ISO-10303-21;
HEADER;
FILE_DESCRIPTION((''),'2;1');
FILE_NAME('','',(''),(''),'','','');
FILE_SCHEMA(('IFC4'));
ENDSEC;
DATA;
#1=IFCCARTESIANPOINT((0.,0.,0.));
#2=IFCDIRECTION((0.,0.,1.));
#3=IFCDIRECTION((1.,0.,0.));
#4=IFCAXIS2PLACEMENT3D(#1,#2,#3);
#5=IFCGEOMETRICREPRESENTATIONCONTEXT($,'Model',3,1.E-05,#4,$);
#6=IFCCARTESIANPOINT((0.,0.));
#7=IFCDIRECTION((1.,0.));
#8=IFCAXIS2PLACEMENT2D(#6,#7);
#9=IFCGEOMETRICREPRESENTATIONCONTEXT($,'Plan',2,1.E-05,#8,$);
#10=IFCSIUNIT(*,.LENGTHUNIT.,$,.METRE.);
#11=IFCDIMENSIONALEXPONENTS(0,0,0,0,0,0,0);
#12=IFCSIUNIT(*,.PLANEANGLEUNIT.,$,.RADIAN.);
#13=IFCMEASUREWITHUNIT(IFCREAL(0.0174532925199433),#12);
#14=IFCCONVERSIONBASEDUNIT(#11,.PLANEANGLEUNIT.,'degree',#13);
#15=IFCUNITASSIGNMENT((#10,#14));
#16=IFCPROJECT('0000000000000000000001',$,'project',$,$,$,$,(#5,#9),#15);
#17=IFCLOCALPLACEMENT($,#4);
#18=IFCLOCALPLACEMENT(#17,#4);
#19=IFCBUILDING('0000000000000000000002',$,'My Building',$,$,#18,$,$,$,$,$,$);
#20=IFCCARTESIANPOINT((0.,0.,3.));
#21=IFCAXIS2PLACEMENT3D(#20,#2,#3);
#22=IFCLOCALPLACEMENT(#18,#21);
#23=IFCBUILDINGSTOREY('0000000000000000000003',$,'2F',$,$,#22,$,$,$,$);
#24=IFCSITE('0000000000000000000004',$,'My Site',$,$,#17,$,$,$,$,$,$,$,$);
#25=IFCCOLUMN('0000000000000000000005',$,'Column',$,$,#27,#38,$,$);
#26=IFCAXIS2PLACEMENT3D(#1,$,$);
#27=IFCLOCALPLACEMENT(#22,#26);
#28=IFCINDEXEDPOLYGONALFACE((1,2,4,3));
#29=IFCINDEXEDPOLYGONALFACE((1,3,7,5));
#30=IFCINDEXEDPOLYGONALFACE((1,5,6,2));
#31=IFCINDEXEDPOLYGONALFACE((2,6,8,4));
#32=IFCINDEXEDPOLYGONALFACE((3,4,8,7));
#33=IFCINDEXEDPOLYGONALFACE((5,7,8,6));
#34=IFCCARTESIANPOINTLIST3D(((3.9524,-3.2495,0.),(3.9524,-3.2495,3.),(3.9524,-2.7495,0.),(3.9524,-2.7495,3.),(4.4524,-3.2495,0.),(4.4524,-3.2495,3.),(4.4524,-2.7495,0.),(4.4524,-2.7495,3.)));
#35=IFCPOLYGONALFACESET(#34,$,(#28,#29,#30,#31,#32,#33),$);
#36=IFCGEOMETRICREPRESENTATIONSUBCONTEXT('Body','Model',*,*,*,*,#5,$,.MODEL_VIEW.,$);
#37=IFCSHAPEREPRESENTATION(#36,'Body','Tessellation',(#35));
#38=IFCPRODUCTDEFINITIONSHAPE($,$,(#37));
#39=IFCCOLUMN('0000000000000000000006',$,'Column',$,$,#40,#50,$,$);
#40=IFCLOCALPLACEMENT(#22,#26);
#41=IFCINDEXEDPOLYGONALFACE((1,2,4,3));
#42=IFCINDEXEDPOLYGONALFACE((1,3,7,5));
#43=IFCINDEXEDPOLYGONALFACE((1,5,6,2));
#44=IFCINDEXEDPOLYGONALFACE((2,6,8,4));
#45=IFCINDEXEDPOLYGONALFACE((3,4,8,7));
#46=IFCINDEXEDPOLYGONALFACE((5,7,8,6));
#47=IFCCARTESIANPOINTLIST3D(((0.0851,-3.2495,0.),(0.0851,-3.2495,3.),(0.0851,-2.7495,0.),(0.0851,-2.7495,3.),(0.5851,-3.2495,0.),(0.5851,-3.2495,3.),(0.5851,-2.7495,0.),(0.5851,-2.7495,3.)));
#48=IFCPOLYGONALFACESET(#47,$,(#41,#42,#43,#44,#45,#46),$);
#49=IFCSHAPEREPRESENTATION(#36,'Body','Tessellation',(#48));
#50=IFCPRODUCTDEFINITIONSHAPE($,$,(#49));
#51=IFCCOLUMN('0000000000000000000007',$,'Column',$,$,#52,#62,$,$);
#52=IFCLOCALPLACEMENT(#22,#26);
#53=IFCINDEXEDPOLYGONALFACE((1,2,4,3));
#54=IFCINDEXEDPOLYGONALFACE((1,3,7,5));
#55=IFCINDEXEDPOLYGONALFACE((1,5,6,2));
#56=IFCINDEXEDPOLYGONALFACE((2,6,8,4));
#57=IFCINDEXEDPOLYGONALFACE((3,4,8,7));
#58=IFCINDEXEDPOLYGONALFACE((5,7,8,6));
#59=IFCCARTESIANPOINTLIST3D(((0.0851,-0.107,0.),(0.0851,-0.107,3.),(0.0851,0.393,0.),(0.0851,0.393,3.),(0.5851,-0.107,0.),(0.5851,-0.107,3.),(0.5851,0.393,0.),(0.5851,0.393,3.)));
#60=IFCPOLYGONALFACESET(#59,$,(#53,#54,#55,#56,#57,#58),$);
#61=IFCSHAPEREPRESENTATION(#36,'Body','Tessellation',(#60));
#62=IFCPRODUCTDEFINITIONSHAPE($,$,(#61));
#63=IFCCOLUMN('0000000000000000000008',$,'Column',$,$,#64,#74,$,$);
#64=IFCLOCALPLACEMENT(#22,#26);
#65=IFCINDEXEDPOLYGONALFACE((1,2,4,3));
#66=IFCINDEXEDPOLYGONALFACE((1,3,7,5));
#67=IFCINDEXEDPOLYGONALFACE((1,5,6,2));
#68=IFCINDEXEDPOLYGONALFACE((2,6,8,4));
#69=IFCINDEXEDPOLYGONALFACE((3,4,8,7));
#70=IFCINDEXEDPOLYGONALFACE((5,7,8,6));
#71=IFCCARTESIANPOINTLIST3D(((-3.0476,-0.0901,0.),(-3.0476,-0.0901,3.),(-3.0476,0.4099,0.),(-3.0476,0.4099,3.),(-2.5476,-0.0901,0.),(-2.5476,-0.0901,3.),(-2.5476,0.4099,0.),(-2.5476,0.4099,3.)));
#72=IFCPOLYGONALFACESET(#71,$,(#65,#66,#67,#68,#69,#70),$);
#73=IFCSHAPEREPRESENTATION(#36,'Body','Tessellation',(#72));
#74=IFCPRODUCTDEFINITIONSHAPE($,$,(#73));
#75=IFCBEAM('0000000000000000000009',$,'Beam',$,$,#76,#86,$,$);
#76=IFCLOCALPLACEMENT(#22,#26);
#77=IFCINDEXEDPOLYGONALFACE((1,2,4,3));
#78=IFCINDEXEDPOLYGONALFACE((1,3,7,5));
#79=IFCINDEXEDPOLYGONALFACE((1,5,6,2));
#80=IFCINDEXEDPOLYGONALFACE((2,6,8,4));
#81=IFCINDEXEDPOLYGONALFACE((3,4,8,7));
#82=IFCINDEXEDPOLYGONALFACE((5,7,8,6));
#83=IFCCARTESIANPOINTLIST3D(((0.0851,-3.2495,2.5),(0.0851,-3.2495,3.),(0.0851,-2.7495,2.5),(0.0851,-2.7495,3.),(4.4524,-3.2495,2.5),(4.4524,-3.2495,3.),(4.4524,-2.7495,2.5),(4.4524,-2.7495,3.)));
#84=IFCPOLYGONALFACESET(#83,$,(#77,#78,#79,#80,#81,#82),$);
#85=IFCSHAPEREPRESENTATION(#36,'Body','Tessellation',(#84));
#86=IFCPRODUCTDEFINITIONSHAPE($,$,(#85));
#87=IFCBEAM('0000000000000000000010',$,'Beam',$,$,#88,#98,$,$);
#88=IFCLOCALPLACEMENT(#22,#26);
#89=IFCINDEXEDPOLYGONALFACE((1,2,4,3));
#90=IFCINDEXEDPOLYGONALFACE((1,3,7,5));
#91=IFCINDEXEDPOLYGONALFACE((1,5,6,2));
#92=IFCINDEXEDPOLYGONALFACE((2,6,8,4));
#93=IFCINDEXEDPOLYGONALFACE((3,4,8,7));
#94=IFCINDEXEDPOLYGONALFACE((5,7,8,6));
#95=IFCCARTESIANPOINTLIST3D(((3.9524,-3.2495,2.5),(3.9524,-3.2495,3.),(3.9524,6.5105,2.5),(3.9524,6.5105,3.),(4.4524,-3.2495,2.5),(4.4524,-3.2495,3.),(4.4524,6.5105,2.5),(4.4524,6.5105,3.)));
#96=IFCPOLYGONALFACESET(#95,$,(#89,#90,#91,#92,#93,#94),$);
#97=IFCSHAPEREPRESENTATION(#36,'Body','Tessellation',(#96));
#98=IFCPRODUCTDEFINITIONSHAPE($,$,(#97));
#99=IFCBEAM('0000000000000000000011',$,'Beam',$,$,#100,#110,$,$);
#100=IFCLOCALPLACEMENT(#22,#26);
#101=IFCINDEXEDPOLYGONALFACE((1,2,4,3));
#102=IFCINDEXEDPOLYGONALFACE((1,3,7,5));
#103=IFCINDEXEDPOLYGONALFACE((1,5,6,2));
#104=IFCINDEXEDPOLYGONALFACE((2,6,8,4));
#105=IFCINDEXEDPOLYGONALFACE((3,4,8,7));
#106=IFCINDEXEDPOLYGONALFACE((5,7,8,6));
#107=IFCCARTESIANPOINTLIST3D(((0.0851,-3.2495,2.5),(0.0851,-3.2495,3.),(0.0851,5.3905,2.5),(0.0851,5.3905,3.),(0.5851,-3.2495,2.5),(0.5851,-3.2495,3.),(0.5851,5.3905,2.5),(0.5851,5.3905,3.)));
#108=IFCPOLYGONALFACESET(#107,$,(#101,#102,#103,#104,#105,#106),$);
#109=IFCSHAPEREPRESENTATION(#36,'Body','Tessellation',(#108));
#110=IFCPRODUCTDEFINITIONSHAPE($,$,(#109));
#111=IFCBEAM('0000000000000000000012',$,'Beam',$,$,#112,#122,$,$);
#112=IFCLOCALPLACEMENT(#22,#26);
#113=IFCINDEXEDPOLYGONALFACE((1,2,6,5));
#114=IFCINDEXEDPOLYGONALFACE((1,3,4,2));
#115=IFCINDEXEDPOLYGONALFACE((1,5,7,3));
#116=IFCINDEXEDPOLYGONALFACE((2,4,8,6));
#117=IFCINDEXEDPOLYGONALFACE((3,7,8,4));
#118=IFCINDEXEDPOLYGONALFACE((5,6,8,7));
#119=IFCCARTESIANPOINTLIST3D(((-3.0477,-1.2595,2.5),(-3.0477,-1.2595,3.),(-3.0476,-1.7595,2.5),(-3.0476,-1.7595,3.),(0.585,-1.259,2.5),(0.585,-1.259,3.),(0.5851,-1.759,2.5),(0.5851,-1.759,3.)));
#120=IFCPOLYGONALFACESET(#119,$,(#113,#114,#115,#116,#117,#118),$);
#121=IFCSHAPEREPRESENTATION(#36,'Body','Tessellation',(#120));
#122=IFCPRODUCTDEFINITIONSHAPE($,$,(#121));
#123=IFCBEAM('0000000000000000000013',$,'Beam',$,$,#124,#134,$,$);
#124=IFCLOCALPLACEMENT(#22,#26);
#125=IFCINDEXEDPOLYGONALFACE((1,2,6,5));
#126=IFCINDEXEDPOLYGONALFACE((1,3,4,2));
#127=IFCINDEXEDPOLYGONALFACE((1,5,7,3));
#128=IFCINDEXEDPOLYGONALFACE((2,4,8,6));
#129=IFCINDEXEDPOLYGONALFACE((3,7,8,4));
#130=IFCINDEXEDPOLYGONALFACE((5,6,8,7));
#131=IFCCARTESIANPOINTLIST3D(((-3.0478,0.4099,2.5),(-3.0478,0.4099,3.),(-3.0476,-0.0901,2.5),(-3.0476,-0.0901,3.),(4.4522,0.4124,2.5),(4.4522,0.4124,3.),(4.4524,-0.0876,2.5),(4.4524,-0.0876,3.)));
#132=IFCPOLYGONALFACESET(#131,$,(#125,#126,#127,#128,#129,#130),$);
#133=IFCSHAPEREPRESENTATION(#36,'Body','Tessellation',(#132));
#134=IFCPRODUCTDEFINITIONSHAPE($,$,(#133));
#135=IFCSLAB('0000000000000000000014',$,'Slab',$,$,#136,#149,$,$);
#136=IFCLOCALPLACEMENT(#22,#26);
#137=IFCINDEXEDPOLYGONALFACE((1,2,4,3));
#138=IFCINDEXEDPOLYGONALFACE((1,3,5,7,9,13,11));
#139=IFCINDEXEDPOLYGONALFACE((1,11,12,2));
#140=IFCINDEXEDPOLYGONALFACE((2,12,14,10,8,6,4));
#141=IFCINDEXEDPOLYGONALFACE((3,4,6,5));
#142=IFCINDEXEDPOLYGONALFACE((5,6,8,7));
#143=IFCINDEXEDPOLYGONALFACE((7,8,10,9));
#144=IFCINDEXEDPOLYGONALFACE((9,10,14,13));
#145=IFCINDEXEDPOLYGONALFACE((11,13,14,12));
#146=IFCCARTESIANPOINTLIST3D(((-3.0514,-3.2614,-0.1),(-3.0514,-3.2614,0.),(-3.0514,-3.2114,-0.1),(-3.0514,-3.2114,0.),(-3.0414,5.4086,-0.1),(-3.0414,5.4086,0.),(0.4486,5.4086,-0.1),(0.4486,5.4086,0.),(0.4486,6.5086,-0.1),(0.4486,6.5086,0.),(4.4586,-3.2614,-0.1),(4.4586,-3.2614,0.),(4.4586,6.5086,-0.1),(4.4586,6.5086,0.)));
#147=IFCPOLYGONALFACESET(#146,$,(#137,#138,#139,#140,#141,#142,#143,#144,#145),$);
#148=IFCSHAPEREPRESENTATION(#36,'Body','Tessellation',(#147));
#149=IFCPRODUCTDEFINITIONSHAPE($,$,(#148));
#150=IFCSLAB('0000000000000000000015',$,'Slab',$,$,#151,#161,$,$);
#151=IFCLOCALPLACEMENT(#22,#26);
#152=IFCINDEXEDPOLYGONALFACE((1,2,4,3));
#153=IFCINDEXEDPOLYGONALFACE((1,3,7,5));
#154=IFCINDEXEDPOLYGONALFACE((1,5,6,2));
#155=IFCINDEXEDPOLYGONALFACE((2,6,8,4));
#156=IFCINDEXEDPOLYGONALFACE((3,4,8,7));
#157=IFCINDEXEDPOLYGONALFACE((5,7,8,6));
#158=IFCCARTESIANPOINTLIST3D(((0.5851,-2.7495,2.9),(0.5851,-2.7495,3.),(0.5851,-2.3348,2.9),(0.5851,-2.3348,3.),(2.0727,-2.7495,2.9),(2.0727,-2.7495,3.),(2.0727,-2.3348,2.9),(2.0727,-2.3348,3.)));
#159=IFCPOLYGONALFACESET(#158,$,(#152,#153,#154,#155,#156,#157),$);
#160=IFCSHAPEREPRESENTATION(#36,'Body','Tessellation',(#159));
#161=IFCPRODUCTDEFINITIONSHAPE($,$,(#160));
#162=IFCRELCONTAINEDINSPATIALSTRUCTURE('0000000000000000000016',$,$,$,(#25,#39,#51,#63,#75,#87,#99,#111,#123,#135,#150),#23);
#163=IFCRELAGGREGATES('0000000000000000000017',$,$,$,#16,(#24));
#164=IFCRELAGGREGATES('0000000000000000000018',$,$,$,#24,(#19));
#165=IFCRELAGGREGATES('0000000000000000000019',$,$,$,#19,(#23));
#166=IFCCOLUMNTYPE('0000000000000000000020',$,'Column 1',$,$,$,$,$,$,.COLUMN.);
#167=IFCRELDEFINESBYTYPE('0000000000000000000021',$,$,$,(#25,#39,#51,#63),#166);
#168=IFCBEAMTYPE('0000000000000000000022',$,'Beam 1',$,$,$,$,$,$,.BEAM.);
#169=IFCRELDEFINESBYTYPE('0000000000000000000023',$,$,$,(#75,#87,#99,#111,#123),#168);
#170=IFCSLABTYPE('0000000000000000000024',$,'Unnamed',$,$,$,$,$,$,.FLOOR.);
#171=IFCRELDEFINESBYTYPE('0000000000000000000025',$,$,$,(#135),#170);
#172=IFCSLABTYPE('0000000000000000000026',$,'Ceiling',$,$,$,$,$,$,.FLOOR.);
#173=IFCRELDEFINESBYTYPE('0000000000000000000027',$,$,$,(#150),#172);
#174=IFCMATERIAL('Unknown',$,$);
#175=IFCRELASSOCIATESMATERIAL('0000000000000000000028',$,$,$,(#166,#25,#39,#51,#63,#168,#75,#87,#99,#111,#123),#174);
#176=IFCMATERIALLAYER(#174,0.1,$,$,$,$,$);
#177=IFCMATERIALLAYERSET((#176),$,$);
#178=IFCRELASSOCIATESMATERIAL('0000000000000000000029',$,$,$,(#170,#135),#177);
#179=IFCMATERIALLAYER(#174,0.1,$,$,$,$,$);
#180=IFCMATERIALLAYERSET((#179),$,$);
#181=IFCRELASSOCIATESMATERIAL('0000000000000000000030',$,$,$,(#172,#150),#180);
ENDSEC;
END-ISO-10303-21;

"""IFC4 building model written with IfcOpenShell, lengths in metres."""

from ifc_helpers import new_model, entity, si_unit, converted_unit, frame, origin_with_axes, origin_2d_with_axis, place, context, subcontext, project, spatial, indexed_curve, outline, extrude, material, layer, layer_set, layer_usage, material_profile, profile_set, profile_usage, type_object, element, save


model = new_model("IFC4")

# Units and contexts
model_context = context("Model", 3, precision=1e-05, world=origin_with_axes())
plan_context = context("Plan", 2, precision=1e-05, world=origin_2d_with_axis())
body_context_1 = subcontext(model_context, "Body", "Model", "MODEL_VIEW")
ifc_project = project(units=[si_unit("LENGTHUNIT", "METRE"), converted_unit("PLANEANGLEUNIT", "degree", entity("IfcReal", 0.0174532925199433), si_unit("PLANEANGLEUNIT", "RADIAN"), dimensions=[0, 0, 0, 0, 0, 0, 0])], contexts=[model_context, plan_context])

# Site, building, storey
site_placement = place(None, origin_with_axes())
site = spatial("IfcSite", under=ifc_project, at=site_placement, Name="My Site")
building_placement = place(site_placement, origin_with_axes())
building = spatial("IfcBuilding", under=site, at=building_placement, Name="My Building")
storey_placement = place(building_placement, frame((0.0, 0.0, 3.0), z_axis=(0.0, 0.0, 1.0), x_axis=(1.0, 0.0, 0.0)))
storey = spatial("IfcBuildingStorey", under=building, at=storey_placement, Name="2F")

# Columns
ifc_material = material(Name="Unknown")
ifc_material_profile_1 = material_profile(ifc_material, outline(indexed_curve([(-0.25, -0.25), (0.25, -0.25), (0.25, 0.25), (-0.25, 0.25), (-0.25, -0.25)])))
ifc_profile_set_1 = profile_set([ifc_material_profile_1])
ifc_profile_usage_1 = profile_usage(ifc_profile_set_1, cardinal=1)
column_type = type_object("IfcColumnType", Name="Column 1", PredefinedType="COLUMN", material=ifc_profile_set_1)
column_1_placement = place(storey_placement, frame((4.4524, -3.2495, 0.0), z_axis=(0.0, 0.0, 1.0), x_axis=(1.0, 0.0, 0.0)))
element("IfcColumn", 1, at=column_1_placement, inside=storey, type_object=column_type, material=ifc_profile_usage_1, Name="Column", context=body_context_1, shape_type="SweptSolid", body=[
    extrude(outline(indexed_curve([(-0.25, -0.25), (0.25, -0.25), (0.25, 0.25), (-0.25, 0.25), (-0.25, -0.25)])), frame((-0.25, 0.25, 0.0), z_axis=(0.0, 0.0, 1.0), x_axis=(1.0, 0.0, 0.0)), (0.0, 0.0, 1.0), 3.0),
])
ifc_profile_usage_2 = profile_usage(ifc_profile_set_1, cardinal=1)
column_2_placement = place(storey_placement, frame((0.5851, -3.2495, 0.0), z_axis=(0.0, 0.0, 1.0), x_axis=(1.0, 0.0, 0.0)))
element("IfcColumn", 2, at=column_2_placement, inside=storey, type_object=column_type, material=ifc_profile_usage_2, Name="Column", context=body_context_1, shape_type="SweptSolid", body=[
    extrude(outline(indexed_curve([(-0.25, -0.25), (0.25, -0.25), (0.25, 0.25), (-0.25, 0.25), (-0.25, -0.25)])), frame((-0.25, 0.25, 0.0), z_axis=(0.0, 0.0, 1.0), x_axis=(1.0, 0.0, 0.0)), (0.0, 0.0, 1.0), 3.0),
])
ifc_profile_usage_3 = profile_usage(ifc_profile_set_1, cardinal=3)
column_3_placement = place(storey_placement, frame((0.0851, -0.107, 0.0), z_axis=(0.0, 0.0, 1.0), x_axis=(1.0, 0.0, 0.0)))
element("IfcColumn", 3, at=column_3_placement, inside=storey, type_object=column_type, material=ifc_profile_usage_3, Name="Column", context=body_context_1, shape_type="SweptSolid", body=[
    extrude(outline(indexed_curve([(-0.25, -0.25), (0.25, -0.25), (0.25, 0.25), (-0.25, 0.25), (-0.25, -0.25)])), frame((0.25, 0.25, 0.0), z_axis=(0.0, 0.0, 1.0), x_axis=(1.0, 0.0, 0.0)), (0.0, 0.0, 1.0), 3.0),
])
ifc_profile_usage_4 = profile_usage(ifc_profile_set_1, cardinal=3)
column_4_placement = place(storey_placement, frame((-3.0476, -0.0901, 0.0), z_axis=(0.0, 0.0, 1.0), x_axis=(1.0, 0.0, 0.0)))
element("IfcColumn", 4, at=column_4_placement, inside=storey, type_object=column_type, material=ifc_profile_usage_4, Name="Column", context=body_context_1, shape_type="SweptSolid", body=[
    extrude(outline(indexed_curve([(-0.25, -0.25), (0.25, -0.25), (0.25, 0.25), (-0.25, 0.25), (-0.25, -0.25)])), frame((0.25, 0.25, 0.0), z_axis=(0.0, 0.0, 1.0), x_axis=(1.0, 0.0, 0.0)), (0.0, 0.0, 1.0), 3.0),
])

# Beams
ifc_material_profile_2 = material_profile(ifc_material, outline(indexed_curve([(-0.25, -0.25), (0.25, -0.25), (0.25, 0.25), (-0.25, 0.25), (-0.25, -0.25)])))
ifc_profile_set_2 = profile_set([ifc_material_profile_2])
ifc_profile_usage_5 = profile_usage(ifc_profile_set_2, cardinal=9)
beam_type = type_object("IfcBeamType", Name="Beam 1", PredefinedType="BEAM", material=ifc_profile_set_2)
beam_1_placement = place(storey_placement, frame((0.0851, -3.2495, 3.0), z_axis=(1.0, -0.000001, 0.000001), x_axis=(0.000001, 1.0, 0.0)))
element("IfcBeam", 5, at=beam_1_placement, inside=storey, type_object=beam_type, material=ifc_profile_usage_5, Name="Beam", context=body_context_1, shape_type="SweptSolid", body=[
    extrude(outline(indexed_curve([(-0.25, -0.25), (0.25, -0.25), (0.25, 0.25), (-0.25, 0.25), (-0.25, -0.25)])), frame((0.25, -0.25, 0.0), z_axis=(0.0, 0.0, 1.0), x_axis=(1.0, 0.0, 0.0)), (0.0, 0.0, 1.0), 4.3673),
])
ifc_profile_usage_6 = profile_usage(ifc_profile_set_2, cardinal=9)
beam_2_placement = place(storey_placement, frame((4.4524, -3.2495, 3.0), z_axis=(0.0, 1.0, 0.0), x_axis=(-1.0, 0.0, 0.0)))
element("IfcBeam", 6, at=beam_2_placement, inside=storey, type_object=beam_type, material=ifc_profile_usage_6, Name="Beam", context=body_context_1, shape_type="SweptSolid", body=[
    extrude(outline(indexed_curve([(-0.25, -0.25), (0.25, -0.25), (0.25, 0.25), (-0.25, 0.25), (-0.25, -0.25)])), frame((0.25, -0.25, 0.0), z_axis=(0.0, 0.0, 1.0), x_axis=(1.0, 0.0, 0.0)), (0.0, 0.0, 1.0), 9.76),
])
ifc_profile_usage_7 = profile_usage(ifc_profile_set_2, cardinal=9)
beam_3_placement = place(storey_placement, frame((0.5851, -3.2495, 3.0), z_axis=(0.0, 1.0, 0.0), x_axis=(-1.0, 0.0, 0.0)))
element("IfcBeam", 7, at=beam_3_placement, inside=storey, type_object=beam_type, material=ifc_profile_usage_7, Name="Beam", context=body_context_1, shape_type="SweptSolid", body=[
    extrude(outline(indexed_curve([(-0.25, -0.25), (0.25, -0.25), (0.25, 0.25), (-0.25, 0.25), (-0.25, -0.25)])), frame((0.25, -0.25, 0.0), z_axis=(0.0, 0.0, 1.0), x_axis=(1.0, 0.0, 0.0)), (0.0, 0.0, 1.0), 8.64),
])
ifc_profile_usage_8 = profile_usage(ifc_profile_set_2, cardinal=9)
beam_4_placement = place(storey_placement, frame((-3.0476, -1.7595, 3.0), z_axis=(1.0, 0.000149, 0.0), x_axis=(-0.000149, 1.0, 0.0)))
element("IfcBeam", 8, at=beam_4_placement, inside=storey, type_object=beam_type, material=ifc_profile_usage_8, Name="Beam", context=body_context_1, shape_type="SweptSolid", body=[
    extrude(outline(indexed_curve([(-0.25, -0.25), (0.25, -0.25), (0.25, 0.25), (-0.25, 0.25), (-0.25, -0.25)])), frame((0.25, -0.25, 0.0), z_axis=(0.0, 0.0, 1.0), x_axis=(1.0, 0.0, 0.0)), (0.0, 0.0, 1.0), 3.6327),
])
ifc_profile_usage_9 = profile_usage(ifc_profile_set_2, cardinal=9)
beam_5_placement = place(storey_placement, frame((-3.0476, -0.0901, 3.0), z_axis=(1.0, 0.000341, 0.0), x_axis=(-0.000341, 1.0, 0.0)))
element("IfcBeam", 9, at=beam_5_placement, inside=storey, type_object=beam_type, material=ifc_profile_usage_9, Name="Beam", context=body_context_1, shape_type="SweptSolid", body=[
    extrude(outline(indexed_curve([(-0.25, -0.25), (0.25, -0.25), (0.25, 0.25), (-0.25, 0.25), (-0.25, -0.25)])), frame((0.25, -0.25, 0.0), z_axis=(0.0, 0.0, 1.0), x_axis=(1.0, 0.0, 0.0)), (0.0, 0.0, 1.0), 7.5),
])

# Slabs
ifc_layer_1 = layer(ifc_material, 0.1)
ifc_layer_set_1 = layer_set([ifc_layer_1])
ifc_layer_usage_1 = layer_usage(ifc_layer_set_1, "AXIS3", "POSITIVE", -0.1)
slab_type_1 = type_object("IfcSlabType", Name="Unnamed", PredefinedType="FLOOR", material=ifc_layer_set_1)
slab_1_placement = place(storey_placement, frame((-3.0514, -3.2114, 0.0), z_axis=(0.0, 0.0, 1.0), x_axis=(1.0, 0.0, 0.0)))
element("IfcSlab", 10, at=slab_1_placement, inside=storey, type_object=slab_type_1, material=ifc_layer_usage_1, Name="Slab", context=body_context_1, shape_type="SweptSolid", body=[
    extrude(outline(indexed_curve([(0.0, 0.0), (0.0, -0.05), (7.51, -0.05), (7.51, 9.72), (3.5, 9.72), (3.5, 8.62), (0.01, 8.62), (0.0, 0.0)])), frame((0.0, 0.0, -0.1), z_axis=(0.0, 0.0, 1.0), x_axis=(1.0, 0.0, 0.0)), (0.0, 0.0, 1.0), 0.1),
])
ifc_layer_2 = layer(ifc_material, 0.1)
ifc_layer_set_2 = layer_set([ifc_layer_2])
ifc_layer_usage_2 = layer_usage(ifc_layer_set_2, "AXIS3", "POSITIVE", -0.1)
slab_type_2 = type_object("IfcSlabType", Name="Ceiling", PredefinedType="FLOOR", material=ifc_layer_set_2)
slab_2_placement = place(storey_placement, frame((2.0727, -2.3348, 3.0), z_axis=(0.0, 0.0, 1.0), x_axis=(1.0, 0.0, 0.0)))
element("IfcSlab", 11, at=slab_2_placement, inside=storey, type_object=slab_type_2, material=ifc_layer_usage_2, Name="Slab", context=body_context_1, shape_type="SweptSolid", body=[
    extrude(outline(indexed_curve([(0.0, 0.0), (0.0, -0.4147), (-1.4876, -0.4147), (-1.4876, 0.0), (0.0, 0.0), (0.0, 0.0)])), frame((0.0, 0.0, -0.1), z_axis=(0.0, 0.0, 1.0), x_axis=(1.0, 0.0, 0.0)), (0.0, 0.0, 1.0), 0.1),
])

save(model, "model.ifc")
